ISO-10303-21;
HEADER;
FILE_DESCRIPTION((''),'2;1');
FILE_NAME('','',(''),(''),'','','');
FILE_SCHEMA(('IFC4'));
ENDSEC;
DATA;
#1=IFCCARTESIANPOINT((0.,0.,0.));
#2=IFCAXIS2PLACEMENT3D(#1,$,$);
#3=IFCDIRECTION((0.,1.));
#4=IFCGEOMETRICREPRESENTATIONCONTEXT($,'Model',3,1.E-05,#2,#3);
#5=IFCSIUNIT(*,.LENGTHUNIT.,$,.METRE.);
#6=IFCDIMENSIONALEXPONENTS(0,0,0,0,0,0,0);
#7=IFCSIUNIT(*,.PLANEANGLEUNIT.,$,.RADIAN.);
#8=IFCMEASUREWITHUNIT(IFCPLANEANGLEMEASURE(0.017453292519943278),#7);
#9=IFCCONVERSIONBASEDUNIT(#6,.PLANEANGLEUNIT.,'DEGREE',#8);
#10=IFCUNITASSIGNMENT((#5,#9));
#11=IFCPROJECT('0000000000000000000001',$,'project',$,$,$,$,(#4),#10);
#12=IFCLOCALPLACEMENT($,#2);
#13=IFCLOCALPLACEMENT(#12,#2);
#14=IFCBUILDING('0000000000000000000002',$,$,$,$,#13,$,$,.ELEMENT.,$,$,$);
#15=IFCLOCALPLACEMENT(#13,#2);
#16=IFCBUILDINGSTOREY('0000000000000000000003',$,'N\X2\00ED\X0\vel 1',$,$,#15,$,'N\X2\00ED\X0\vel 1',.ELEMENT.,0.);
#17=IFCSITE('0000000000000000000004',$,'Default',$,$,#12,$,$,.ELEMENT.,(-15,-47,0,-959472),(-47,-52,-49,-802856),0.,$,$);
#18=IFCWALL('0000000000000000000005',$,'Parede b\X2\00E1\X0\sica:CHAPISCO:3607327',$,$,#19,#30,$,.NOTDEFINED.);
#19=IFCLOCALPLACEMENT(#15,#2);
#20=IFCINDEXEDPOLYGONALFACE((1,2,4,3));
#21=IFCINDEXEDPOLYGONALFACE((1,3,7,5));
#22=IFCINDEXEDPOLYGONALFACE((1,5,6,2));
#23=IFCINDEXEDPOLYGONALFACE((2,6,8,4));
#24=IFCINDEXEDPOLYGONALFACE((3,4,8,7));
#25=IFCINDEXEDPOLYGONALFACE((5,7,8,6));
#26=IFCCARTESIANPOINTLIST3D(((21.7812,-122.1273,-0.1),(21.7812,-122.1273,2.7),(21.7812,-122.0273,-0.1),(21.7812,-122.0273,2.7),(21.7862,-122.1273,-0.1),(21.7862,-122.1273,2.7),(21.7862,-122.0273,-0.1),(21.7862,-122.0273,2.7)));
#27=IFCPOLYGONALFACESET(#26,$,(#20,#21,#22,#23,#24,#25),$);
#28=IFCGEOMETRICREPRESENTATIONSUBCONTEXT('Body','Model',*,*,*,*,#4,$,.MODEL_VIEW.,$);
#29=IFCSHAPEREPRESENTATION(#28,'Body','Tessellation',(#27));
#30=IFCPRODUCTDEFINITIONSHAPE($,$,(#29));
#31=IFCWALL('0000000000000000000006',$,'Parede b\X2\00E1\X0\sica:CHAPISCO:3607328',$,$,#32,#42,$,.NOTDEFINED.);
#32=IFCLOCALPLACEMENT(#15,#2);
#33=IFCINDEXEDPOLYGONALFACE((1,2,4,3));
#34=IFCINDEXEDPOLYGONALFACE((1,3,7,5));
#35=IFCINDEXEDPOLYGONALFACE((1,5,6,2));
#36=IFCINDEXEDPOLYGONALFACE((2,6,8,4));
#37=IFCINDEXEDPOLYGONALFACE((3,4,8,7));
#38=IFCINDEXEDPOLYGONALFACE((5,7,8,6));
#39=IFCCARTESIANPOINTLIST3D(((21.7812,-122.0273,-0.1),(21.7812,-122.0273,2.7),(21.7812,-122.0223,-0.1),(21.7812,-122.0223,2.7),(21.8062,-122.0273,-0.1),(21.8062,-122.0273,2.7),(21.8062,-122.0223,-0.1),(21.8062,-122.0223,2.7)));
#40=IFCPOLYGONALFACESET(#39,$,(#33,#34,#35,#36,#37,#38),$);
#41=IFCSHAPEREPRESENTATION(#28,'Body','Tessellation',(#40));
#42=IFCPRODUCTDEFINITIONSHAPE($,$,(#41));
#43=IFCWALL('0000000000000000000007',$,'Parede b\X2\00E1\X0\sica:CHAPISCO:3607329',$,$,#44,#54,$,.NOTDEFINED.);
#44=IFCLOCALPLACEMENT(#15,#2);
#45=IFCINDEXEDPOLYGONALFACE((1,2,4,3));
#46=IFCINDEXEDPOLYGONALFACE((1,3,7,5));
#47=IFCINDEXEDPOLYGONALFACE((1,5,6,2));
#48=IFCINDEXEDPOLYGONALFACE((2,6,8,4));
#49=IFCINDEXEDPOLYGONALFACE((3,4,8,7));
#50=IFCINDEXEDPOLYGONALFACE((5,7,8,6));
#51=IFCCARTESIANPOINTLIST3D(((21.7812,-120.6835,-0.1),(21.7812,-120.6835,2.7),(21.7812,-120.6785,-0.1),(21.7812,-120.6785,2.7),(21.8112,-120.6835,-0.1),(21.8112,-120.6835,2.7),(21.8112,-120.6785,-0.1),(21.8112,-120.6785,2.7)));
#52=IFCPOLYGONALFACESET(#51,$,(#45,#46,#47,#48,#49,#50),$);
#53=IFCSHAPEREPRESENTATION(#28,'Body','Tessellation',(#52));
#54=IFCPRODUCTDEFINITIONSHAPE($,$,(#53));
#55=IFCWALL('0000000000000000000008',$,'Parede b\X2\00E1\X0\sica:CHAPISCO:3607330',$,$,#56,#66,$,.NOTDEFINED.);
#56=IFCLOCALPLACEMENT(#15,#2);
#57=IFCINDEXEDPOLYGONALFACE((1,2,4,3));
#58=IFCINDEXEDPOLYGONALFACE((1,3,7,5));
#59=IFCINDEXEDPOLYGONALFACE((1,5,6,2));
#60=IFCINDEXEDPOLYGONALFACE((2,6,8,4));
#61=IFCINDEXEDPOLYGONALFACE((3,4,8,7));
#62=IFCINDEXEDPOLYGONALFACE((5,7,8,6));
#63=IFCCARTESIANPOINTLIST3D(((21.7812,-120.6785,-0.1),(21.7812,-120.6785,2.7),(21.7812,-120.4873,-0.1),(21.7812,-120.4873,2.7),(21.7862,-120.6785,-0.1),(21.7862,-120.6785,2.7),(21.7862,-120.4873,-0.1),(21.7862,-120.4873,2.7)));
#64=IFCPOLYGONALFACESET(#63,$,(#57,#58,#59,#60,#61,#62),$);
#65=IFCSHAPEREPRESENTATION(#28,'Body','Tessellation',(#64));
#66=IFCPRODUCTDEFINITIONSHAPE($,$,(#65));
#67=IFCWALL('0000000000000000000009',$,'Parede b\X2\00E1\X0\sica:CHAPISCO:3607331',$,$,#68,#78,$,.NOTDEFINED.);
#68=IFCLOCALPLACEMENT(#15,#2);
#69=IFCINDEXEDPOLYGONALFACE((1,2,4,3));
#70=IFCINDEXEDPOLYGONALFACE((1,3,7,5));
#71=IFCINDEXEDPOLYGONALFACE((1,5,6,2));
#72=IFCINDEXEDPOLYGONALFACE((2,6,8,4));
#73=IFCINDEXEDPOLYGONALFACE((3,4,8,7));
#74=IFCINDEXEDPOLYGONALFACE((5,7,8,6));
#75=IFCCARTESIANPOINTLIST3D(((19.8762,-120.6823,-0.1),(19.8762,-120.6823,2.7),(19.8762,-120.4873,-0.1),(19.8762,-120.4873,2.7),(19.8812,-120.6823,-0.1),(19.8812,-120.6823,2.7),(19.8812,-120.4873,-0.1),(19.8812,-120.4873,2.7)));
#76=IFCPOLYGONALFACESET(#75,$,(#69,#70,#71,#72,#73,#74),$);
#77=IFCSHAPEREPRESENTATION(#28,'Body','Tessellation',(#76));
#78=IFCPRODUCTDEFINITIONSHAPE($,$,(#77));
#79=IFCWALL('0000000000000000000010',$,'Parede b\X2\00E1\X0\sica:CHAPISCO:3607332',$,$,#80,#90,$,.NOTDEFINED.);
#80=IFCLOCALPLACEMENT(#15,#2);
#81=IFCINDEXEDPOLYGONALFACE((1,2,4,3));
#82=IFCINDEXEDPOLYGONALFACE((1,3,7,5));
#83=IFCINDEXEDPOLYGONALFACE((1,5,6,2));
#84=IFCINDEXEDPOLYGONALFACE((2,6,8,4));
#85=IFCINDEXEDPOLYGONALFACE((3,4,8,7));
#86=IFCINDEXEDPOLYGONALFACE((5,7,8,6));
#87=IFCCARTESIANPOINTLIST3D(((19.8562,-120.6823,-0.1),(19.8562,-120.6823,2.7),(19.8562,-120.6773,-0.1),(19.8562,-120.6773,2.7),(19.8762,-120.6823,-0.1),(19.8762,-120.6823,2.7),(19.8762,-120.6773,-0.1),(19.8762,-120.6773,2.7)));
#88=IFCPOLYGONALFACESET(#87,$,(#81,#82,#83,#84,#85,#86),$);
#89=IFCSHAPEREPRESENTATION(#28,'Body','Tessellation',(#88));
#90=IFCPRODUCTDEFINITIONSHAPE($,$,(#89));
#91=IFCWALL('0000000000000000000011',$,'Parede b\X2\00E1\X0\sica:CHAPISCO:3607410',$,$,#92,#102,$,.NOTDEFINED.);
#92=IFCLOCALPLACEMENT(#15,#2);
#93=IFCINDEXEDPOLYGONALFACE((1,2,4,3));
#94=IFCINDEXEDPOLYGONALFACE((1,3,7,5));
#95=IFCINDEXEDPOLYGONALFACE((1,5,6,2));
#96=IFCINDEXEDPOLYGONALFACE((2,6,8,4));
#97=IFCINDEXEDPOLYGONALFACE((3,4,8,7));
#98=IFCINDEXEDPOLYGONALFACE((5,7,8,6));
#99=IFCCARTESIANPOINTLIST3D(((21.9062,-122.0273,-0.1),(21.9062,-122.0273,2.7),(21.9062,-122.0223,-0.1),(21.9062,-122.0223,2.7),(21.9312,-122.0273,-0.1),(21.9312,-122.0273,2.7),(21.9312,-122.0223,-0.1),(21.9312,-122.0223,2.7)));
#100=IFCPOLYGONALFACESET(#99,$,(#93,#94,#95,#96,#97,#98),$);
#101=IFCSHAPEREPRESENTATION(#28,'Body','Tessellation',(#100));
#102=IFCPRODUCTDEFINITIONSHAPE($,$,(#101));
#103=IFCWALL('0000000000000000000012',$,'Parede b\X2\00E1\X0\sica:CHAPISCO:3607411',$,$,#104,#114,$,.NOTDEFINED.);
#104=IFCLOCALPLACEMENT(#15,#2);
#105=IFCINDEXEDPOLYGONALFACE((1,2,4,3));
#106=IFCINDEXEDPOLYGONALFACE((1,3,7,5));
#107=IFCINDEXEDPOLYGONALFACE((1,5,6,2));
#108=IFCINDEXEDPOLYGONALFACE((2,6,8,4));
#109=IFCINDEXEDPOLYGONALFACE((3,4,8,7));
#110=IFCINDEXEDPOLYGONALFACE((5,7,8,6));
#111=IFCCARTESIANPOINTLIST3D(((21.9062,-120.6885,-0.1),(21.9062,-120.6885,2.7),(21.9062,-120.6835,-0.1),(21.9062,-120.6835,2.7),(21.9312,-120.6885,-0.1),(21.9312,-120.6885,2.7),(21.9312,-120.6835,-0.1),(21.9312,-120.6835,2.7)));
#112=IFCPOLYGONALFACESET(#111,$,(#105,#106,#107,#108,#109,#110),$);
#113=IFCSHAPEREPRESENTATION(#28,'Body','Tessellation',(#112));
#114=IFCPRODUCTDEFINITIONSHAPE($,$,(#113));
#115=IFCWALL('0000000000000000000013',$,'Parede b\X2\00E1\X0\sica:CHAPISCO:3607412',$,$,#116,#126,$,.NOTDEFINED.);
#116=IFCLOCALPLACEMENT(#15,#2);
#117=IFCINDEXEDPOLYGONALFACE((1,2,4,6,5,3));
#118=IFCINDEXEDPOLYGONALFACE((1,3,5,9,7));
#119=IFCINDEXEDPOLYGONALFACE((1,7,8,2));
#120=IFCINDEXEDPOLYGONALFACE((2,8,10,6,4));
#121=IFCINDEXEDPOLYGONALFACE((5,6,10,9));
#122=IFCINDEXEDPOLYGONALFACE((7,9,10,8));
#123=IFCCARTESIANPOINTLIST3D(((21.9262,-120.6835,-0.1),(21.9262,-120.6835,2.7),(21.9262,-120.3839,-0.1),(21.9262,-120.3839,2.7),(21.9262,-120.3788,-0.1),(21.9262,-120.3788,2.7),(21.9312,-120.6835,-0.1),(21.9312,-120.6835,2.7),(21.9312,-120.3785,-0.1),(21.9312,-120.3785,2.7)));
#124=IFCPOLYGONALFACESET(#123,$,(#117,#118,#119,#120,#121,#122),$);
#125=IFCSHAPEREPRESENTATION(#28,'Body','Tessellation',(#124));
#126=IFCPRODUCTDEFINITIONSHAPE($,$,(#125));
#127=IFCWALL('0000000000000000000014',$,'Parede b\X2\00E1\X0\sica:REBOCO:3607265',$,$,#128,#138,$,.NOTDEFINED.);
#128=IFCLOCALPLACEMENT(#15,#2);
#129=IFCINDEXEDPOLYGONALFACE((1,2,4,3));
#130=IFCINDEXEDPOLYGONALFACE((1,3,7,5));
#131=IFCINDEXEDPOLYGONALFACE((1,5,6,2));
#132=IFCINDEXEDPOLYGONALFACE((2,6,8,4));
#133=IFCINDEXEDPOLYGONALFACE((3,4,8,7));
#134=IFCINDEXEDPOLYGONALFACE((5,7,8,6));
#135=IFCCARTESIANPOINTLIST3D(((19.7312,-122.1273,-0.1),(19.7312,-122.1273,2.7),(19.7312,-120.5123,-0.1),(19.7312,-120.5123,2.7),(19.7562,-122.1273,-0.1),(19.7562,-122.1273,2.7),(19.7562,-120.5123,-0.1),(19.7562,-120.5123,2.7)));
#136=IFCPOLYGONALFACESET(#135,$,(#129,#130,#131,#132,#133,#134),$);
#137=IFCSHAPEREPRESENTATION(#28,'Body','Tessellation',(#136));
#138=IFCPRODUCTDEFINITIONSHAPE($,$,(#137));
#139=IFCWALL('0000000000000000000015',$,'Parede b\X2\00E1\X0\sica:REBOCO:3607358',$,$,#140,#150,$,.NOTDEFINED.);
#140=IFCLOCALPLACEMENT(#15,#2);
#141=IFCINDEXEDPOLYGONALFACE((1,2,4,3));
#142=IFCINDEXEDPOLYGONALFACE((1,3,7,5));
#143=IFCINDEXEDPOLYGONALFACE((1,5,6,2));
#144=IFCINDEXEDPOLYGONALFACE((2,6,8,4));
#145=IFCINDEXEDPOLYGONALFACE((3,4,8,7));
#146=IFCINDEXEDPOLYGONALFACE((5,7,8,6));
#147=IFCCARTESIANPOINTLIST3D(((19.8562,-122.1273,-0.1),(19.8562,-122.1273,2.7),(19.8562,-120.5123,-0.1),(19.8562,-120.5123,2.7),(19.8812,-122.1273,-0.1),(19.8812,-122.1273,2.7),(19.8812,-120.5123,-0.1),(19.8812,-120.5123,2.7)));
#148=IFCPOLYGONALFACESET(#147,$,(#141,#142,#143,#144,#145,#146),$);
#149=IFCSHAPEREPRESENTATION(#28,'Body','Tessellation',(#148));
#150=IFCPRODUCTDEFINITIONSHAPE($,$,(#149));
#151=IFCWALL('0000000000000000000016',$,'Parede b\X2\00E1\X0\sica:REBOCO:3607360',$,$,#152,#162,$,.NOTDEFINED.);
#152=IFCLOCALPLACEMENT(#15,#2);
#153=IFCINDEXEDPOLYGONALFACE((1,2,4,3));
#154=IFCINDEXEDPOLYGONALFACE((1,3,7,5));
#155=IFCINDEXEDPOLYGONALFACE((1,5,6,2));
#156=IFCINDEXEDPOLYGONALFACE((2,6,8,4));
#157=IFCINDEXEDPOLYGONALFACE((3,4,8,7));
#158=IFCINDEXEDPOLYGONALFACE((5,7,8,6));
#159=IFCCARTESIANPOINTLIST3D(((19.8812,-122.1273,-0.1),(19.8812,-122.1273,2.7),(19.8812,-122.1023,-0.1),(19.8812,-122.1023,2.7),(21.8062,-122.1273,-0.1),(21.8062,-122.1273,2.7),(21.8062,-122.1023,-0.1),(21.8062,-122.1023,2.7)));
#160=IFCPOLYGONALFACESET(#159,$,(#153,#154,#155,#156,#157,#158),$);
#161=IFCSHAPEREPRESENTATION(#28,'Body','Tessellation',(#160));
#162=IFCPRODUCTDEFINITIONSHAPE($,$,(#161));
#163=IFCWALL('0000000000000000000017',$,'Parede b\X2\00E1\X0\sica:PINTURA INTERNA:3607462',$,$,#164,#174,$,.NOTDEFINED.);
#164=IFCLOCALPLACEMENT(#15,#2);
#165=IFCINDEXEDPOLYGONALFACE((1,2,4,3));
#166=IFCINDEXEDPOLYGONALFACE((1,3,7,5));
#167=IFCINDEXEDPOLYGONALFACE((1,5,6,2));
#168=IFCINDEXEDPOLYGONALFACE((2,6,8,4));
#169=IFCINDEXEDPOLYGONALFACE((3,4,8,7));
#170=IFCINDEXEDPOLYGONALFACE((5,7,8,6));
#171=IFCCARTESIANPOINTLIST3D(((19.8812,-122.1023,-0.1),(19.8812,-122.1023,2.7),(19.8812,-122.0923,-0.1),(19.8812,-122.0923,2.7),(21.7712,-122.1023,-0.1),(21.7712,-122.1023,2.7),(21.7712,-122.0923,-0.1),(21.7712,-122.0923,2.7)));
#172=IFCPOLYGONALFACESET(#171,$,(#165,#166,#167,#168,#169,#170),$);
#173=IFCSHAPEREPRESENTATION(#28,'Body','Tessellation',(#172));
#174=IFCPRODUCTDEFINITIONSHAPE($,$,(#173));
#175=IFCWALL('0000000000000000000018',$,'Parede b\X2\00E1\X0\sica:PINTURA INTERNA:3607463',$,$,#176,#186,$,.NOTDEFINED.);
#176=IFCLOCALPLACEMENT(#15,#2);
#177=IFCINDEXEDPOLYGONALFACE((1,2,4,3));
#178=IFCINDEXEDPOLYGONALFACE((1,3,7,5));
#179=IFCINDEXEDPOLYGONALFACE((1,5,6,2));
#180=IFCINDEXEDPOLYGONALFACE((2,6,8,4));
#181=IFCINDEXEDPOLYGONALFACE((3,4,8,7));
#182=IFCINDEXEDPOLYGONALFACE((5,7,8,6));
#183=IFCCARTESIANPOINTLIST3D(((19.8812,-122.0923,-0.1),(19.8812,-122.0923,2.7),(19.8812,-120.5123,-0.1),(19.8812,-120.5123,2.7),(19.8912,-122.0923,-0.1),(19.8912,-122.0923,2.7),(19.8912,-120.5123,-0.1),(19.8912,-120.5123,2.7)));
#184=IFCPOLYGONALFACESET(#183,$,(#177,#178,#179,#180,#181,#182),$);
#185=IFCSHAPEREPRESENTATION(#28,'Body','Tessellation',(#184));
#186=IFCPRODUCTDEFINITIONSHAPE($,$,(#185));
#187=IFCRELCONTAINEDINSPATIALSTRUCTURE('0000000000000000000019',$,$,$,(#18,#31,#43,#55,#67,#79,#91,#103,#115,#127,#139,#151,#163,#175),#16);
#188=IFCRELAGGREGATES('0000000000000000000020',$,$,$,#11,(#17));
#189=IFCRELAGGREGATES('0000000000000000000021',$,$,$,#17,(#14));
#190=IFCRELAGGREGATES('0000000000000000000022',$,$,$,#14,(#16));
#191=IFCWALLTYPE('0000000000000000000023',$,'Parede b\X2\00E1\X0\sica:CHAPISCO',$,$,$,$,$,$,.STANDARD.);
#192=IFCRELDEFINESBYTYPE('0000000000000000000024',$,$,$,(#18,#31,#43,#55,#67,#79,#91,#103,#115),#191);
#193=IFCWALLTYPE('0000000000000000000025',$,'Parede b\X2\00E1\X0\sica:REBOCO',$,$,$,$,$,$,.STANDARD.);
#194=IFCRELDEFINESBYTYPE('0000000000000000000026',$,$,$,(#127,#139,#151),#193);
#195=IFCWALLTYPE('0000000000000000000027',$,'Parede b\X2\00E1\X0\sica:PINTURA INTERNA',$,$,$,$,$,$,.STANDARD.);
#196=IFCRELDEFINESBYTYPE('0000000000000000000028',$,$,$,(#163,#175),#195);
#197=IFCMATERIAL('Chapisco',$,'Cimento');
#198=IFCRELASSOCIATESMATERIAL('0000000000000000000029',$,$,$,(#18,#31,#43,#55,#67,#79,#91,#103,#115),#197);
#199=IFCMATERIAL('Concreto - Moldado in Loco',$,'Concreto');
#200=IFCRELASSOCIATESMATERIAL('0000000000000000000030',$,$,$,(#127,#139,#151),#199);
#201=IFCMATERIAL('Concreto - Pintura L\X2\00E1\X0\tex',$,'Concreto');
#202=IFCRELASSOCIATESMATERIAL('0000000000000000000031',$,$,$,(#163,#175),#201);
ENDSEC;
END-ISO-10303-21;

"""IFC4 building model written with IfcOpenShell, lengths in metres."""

from ifc_helpers import new_model, entity, si_unit, converted_unit, direction, frame, origin, place, context, subcontext, project, spatial, indexed_curve, outline, extrude, material, type_object, element, save


model = new_model("IFC4")

# Units and contexts
model_context = context("Model", 3, precision=1e-05, world=origin(), true_north=direction((0.0, 1.0)))
body_context = subcontext(model_context, "Body", "Model", "MODEL_VIEW")
ifc_project = project(units=[si_unit("LENGTHUNIT", "METRE"), converted_unit("PLANEANGLEUNIT", "DEGREE", entity("IfcPlaneAngleMeasure", 0.017453292519943278), si_unit("PLANEANGLEUNIT", "RADIAN"), dimensions=[0, 0, 0, 0, 0, 0, 0])], contexts=[model_context])

# Site, building, storey
site_placement = place(None, origin())
site = spatial("IfcSite", under=ifc_project, at=site_placement, Name="Default", CompositionType="ELEMENT", RefLatitude=(-15, -47, 0, -959472), RefLongitude=(-47, -52, -49, -802856), RefElevation=0.0)
building_placement = place(site_placement, origin())
building = spatial("IfcBuilding", under=site, at=building_placement, CompositionType="ELEMENT")
storey_placement = place(building_placement, origin())
storey = spatial("IfcBuildingStorey", under=building, at=storey_placement, Name="Nível 1", LongName="Nível 1", CompositionType="ELEMENT", Elevation=0.0)

# Walls
ifc_material_1 = material(Name="Chapisco", Category="Cimento")
wall_type_1 = type_object("IfcWallType", Name="Parede básica:CHAPISCO", PredefinedType="STANDARD")
for number, where, z_axis, x_axis, name in (
    (1, (21.7837, -122.1273, -0.1), (0.0, 0.0, 1.0), (0.0, 1.0, 0.0), "Parede básica:CHAPISCO:3607327"),
):
    element("IfcWall", number, at=place(storey_placement, frame(where, z_axis=z_axis, x_axis=x_axis)), inside=storey, type_object=wall_type_1, material=ifc_material_1, Name=name, PredefinedType="NOTDEFINED", context=body_context, shape_type="SweptSolid", body=[
        extrude(outline(indexed_curve([(0.1, 0.0025), (0.0, 0.0025), (0.0, -0.0025), (0.1, -0.0025), (0.1, 0.0025)], self_intersect=False)), origin(), (0.0, 0.0, 1.0), 2.8),
    ])
wall_1_placement = place(storey_placement, frame((21.7812, -122.0248, -0.1)))
element("IfcWall", 2, at=wall_1_placement, inside=storey, type_object=wall_type_1, material=ifc_material_1, Name="Parede básica:CHAPISCO:3607328", PredefinedType="NOTDEFINED", context=body_context, shape_type="SweptSolid", body=[
    extrude(outline(indexed_curve([(0.025, 0.0025), (0.0, 0.0025), (0.0, -0.0025), (0.025, -0.0025), (0.025, 0.0025)], self_intersect=False)), origin(), (0.0, 0.0, 1.0), 2.8),
])
wall_2_placement = place(storey_placement, frame((21.8112, -120.681, -0.1), z_axis=(0.0, 0.0, 1.0), x_axis=(-1.0, 0.0, 0.0)))
element("IfcWall", 3, at=wall_2_placement, inside=storey, type_object=wall_type_1, material=ifc_material_1, Name="Parede básica:CHAPISCO:3607329", PredefinedType="NOTDEFINED", context=body_context, shape_type="SweptSolid", body=[
    extrude(outline(indexed_curve([(0.03, 0.0025), (0.0, 0.0025), (0.0, -0.0025), (0.03, -0.0025), (0.03, 0.0025)], self_intersect=False)), origin(), (0.0, 0.0, 1.0), 2.8),
])
wall_3_placement = place(storey_placement, frame((21.7837, -120.6785, -0.1), z_axis=(0.0, 0.0, 1.0), x_axis=(0.0, 1.0, 0.0)))
element("IfcWall", 4, at=wall_3_placement, inside=storey, type_object=wall_type_1, material=ifc_material_1, Name="Parede básica:CHAPISCO:3607330", PredefinedType="NOTDEFINED", context=body_context, shape_type="SweptSolid", body=[
    extrude(outline(indexed_curve([(0.1913, 0.0025), (0.0, 0.0025), (0.0, -0.0025), (0.1913, -0.0025), (0.1913, 0.0025)], self_intersect=False)), origin(), (0.0, 0.0, 1.0), 2.8),
])
wall_4_placement = place(storey_placement, frame((19.8787, -120.4873, -0.1), z_axis=(0.0, 0.0, 1.0), x_axis=(0.0, -1.0, 0.0)))
element("IfcWall", 5, at=wall_4_placement, inside=storey, type_object=wall_type_1, material=ifc_material_1, Name="Parede básica:CHAPISCO:3607331", PredefinedType="NOTDEFINED", context=body_context, shape_type="SweptSolid", body=[
    extrude(outline(indexed_curve([(0.195, 0.0025), (0.0, 0.0025), (0.0, -0.0025), (0.195, -0.0025), (0.195, 0.0025)], self_intersect=False)), origin(), (0.0, 0.0, 1.0), 2.8),
])
wall_5_placement = place(storey_placement, frame((19.8762, -120.6798, -0.1), z_axis=(0.0, 0.0, 1.0), x_axis=(-1.0, 0.0, 0.0)))
element("IfcWall", 6, at=wall_5_placement, inside=storey, type_object=wall_type_1, material=ifc_material_1, Name="Parede básica:CHAPISCO:3607332", PredefinedType="NOTDEFINED", context=body_context, shape_type="SweptSolid", body=[
    extrude(outline(indexed_curve([(0.02, 0.0025), (0.0, 0.0025), (0.0, -0.0025), (0.02, -0.0025), (0.02, 0.0025)], self_intersect=False)), origin(), (0.0, 0.0, 1.0), 2.8),
])
wall_6_placement = place(storey_placement, frame((21.9312, -122.0248, -0.1), z_axis=(0.0, 0.0, 1.0), x_axis=(-1.0, 0.0, 0.0)))
element("IfcWall", 7, at=wall_6_placement, inside=storey, type_object=wall_type_1, material=ifc_material_1, Name="Parede básica:CHAPISCO:3607410", PredefinedType="NOTDEFINED", context=body_context, shape_type="SweptSolid", body=[
    extrude(outline(indexed_curve([(0.025, 0.0025), (0.0, 0.0025), (0.0, -0.0025), (0.025, -0.0025), (0.025, 0.0025)], self_intersect=False)), origin(), (0.0, 0.0, 1.0), 2.8),
])
wall_7_placement = place(storey_placement, frame((21.9062, -120.686, -0.1)))
element("IfcWall", 8, at=wall_7_placement, inside=storey, type_object=wall_type_1, material=ifc_material_1, Name="Parede básica:CHAPISCO:3607411", PredefinedType="NOTDEFINED", context=body_context, shape_type="SweptSolid", body=[
    extrude(outline(indexed_curve([(0.025, 0.0025), (0.0, 0.0025), (0.0, -0.0025), (0.025, -0.0025), (0.025, 0.0025)], self_intersect=False)), origin(), (0.0, 0.0, 1.0), 2.8),
])
wall_8_placement = place(storey_placement, frame((21.9287, -120.6835, -0.1), z_axis=(0.0, 0.0, 1.0), x_axis=(0.0, 1.0, 0.0)))
element("IfcWall", 9, at=wall_8_placement, inside=storey, type_object=wall_type_1, material=ifc_material_1, Name="Parede básica:CHAPISCO:3607412", PredefinedType="NOTDEFINED", context=body_context, shape_type="SweptSolid", body=[
    extrude(outline(indexed_curve([(0.305, -0.0025), (0.3047, 0.0025), (0.2997, 0.0025), (0.0, 0.0025), (0.0, -0.0025), (0.305, -0.0025)], self_intersect=False)), origin(), (0.0, 0.0, 1.0), 2.8),
])
ifc_material_2 = material(Name="Concreto - Moldado in Loco", Category="Concreto")
wall_type_2 = type_object("IfcWallType", Name="Parede básica:REBOCO", PredefinedType="STANDARD")
wall_9_placement = place(storey_placement, frame((19.7437, -120.5123, -0.1), z_axis=(0.0, 0.0, 1.0), x_axis=(0.0, -1.0, 0.0)))
element("IfcWall", 10, at=wall_9_placement, inside=storey, type_object=wall_type_2, material=ifc_material_2, Name="Parede básica:REBOCO:3607265", PredefinedType="NOTDEFINED", context=body_context, shape_type="SweptSolid", body=[
    extrude(outline(indexed_curve([(1.615, 0.0125), (0.0, 0.0125), (0.0, -0.0125), (1.615, -0.0125), (1.615, 0.0125)], self_intersect=False)), origin(), (0.0, 0.0, 1.0), 2.8),
])
wall_10_placement = place(storey_placement, frame((19.8687, -122.1273, -0.1), z_axis=(0.0, 0.0, 1.0), x_axis=(0.0, 1.0, 0.0)))
element("IfcWall", 11, at=wall_10_placement, inside=storey, type_object=wall_type_2, material=ifc_material_2, Name="Parede básica:REBOCO:3607358", PredefinedType="NOTDEFINED", context=body_context, shape_type="SweptSolid", body=[
    extrude(outline(indexed_curve([(1.615, 0.0125), (0.0, 0.0125), (0.0, -0.0125), (1.615, -0.0125), (1.615, 0.0125)], self_intersect=False)), origin(), (0.0, 0.0, 1.0), 2.8),
])
wall_11_placement = place(storey_placement, frame((21.8062, -122.1148, -0.1), z_axis=(0.0, 0.0, 1.0), x_axis=(-1.0, 0.0, 0.0)))
element("IfcWall", 12, at=wall_11_placement, inside=storey, type_object=wall_type_2, material=ifc_material_2, Name="Parede básica:REBOCO:3607360", PredefinedType="NOTDEFINED", context=body_context, shape_type="SweptSolid", body=[
    extrude(outline(indexed_curve([(1.925, 0.0125), (0.0, 0.0125), (0.0, -0.0125), (1.925, -0.0125), (1.925, 0.0125)], self_intersect=False)), origin(), (0.0, 0.0, 1.0), 2.8),
])
ifc_material_3 = material(Name="Concreto - Pintura Látex", Category="Concreto")
wall_type_3 = type_object("IfcWallType", Name="Parede básica:PINTURA INTERNA", PredefinedType="STANDARD")
wall_12_placement = place(storey_placement, frame((19.8812, -122.0973, -0.1)))
element("IfcWall", 13, at=wall_12_placement, inside=storey, type_object=wall_type_3, material=ifc_material_3, Name="Parede básica:PINTURA INTERNA:3607462", PredefinedType="NOTDEFINED", context=body_context, shape_type="SweptSolid", body=[
    extrude(outline(indexed_curve([(1.89, 0.005), (0.0, 0.005), (0.0, -0.005), (1.89, -0.005), (1.89, 0.005)], self_intersect=False)), origin(), (0.0, 0.0, 1.0), 2.8),
])
wall_13_placement = place(storey_placement, frame((19.8862, -120.5123, -0.1), z_axis=(0.0, 0.0, 1.0), x_axis=(0.0, -1.0, 0.0)))
element("IfcWall", 14, at=wall_13_placement, inside=storey, type_object=wall_type_3, material=ifc_material_3, Name="Parede básica:PINTURA INTERNA:3607463", PredefinedType="NOTDEFINED", context=body_context, shape_type="SweptSolid", body=[
    extrude(outline(indexed_curve([(1.58, 0.005), (0.0, 0.005), (0.0, -0.005), (1.58, -0.005), (1.58, 0.005)], self_intersect=False)), origin(), (0.0, 0.0, 1.0), 2.8),
])

save(model, "model.ifc")
